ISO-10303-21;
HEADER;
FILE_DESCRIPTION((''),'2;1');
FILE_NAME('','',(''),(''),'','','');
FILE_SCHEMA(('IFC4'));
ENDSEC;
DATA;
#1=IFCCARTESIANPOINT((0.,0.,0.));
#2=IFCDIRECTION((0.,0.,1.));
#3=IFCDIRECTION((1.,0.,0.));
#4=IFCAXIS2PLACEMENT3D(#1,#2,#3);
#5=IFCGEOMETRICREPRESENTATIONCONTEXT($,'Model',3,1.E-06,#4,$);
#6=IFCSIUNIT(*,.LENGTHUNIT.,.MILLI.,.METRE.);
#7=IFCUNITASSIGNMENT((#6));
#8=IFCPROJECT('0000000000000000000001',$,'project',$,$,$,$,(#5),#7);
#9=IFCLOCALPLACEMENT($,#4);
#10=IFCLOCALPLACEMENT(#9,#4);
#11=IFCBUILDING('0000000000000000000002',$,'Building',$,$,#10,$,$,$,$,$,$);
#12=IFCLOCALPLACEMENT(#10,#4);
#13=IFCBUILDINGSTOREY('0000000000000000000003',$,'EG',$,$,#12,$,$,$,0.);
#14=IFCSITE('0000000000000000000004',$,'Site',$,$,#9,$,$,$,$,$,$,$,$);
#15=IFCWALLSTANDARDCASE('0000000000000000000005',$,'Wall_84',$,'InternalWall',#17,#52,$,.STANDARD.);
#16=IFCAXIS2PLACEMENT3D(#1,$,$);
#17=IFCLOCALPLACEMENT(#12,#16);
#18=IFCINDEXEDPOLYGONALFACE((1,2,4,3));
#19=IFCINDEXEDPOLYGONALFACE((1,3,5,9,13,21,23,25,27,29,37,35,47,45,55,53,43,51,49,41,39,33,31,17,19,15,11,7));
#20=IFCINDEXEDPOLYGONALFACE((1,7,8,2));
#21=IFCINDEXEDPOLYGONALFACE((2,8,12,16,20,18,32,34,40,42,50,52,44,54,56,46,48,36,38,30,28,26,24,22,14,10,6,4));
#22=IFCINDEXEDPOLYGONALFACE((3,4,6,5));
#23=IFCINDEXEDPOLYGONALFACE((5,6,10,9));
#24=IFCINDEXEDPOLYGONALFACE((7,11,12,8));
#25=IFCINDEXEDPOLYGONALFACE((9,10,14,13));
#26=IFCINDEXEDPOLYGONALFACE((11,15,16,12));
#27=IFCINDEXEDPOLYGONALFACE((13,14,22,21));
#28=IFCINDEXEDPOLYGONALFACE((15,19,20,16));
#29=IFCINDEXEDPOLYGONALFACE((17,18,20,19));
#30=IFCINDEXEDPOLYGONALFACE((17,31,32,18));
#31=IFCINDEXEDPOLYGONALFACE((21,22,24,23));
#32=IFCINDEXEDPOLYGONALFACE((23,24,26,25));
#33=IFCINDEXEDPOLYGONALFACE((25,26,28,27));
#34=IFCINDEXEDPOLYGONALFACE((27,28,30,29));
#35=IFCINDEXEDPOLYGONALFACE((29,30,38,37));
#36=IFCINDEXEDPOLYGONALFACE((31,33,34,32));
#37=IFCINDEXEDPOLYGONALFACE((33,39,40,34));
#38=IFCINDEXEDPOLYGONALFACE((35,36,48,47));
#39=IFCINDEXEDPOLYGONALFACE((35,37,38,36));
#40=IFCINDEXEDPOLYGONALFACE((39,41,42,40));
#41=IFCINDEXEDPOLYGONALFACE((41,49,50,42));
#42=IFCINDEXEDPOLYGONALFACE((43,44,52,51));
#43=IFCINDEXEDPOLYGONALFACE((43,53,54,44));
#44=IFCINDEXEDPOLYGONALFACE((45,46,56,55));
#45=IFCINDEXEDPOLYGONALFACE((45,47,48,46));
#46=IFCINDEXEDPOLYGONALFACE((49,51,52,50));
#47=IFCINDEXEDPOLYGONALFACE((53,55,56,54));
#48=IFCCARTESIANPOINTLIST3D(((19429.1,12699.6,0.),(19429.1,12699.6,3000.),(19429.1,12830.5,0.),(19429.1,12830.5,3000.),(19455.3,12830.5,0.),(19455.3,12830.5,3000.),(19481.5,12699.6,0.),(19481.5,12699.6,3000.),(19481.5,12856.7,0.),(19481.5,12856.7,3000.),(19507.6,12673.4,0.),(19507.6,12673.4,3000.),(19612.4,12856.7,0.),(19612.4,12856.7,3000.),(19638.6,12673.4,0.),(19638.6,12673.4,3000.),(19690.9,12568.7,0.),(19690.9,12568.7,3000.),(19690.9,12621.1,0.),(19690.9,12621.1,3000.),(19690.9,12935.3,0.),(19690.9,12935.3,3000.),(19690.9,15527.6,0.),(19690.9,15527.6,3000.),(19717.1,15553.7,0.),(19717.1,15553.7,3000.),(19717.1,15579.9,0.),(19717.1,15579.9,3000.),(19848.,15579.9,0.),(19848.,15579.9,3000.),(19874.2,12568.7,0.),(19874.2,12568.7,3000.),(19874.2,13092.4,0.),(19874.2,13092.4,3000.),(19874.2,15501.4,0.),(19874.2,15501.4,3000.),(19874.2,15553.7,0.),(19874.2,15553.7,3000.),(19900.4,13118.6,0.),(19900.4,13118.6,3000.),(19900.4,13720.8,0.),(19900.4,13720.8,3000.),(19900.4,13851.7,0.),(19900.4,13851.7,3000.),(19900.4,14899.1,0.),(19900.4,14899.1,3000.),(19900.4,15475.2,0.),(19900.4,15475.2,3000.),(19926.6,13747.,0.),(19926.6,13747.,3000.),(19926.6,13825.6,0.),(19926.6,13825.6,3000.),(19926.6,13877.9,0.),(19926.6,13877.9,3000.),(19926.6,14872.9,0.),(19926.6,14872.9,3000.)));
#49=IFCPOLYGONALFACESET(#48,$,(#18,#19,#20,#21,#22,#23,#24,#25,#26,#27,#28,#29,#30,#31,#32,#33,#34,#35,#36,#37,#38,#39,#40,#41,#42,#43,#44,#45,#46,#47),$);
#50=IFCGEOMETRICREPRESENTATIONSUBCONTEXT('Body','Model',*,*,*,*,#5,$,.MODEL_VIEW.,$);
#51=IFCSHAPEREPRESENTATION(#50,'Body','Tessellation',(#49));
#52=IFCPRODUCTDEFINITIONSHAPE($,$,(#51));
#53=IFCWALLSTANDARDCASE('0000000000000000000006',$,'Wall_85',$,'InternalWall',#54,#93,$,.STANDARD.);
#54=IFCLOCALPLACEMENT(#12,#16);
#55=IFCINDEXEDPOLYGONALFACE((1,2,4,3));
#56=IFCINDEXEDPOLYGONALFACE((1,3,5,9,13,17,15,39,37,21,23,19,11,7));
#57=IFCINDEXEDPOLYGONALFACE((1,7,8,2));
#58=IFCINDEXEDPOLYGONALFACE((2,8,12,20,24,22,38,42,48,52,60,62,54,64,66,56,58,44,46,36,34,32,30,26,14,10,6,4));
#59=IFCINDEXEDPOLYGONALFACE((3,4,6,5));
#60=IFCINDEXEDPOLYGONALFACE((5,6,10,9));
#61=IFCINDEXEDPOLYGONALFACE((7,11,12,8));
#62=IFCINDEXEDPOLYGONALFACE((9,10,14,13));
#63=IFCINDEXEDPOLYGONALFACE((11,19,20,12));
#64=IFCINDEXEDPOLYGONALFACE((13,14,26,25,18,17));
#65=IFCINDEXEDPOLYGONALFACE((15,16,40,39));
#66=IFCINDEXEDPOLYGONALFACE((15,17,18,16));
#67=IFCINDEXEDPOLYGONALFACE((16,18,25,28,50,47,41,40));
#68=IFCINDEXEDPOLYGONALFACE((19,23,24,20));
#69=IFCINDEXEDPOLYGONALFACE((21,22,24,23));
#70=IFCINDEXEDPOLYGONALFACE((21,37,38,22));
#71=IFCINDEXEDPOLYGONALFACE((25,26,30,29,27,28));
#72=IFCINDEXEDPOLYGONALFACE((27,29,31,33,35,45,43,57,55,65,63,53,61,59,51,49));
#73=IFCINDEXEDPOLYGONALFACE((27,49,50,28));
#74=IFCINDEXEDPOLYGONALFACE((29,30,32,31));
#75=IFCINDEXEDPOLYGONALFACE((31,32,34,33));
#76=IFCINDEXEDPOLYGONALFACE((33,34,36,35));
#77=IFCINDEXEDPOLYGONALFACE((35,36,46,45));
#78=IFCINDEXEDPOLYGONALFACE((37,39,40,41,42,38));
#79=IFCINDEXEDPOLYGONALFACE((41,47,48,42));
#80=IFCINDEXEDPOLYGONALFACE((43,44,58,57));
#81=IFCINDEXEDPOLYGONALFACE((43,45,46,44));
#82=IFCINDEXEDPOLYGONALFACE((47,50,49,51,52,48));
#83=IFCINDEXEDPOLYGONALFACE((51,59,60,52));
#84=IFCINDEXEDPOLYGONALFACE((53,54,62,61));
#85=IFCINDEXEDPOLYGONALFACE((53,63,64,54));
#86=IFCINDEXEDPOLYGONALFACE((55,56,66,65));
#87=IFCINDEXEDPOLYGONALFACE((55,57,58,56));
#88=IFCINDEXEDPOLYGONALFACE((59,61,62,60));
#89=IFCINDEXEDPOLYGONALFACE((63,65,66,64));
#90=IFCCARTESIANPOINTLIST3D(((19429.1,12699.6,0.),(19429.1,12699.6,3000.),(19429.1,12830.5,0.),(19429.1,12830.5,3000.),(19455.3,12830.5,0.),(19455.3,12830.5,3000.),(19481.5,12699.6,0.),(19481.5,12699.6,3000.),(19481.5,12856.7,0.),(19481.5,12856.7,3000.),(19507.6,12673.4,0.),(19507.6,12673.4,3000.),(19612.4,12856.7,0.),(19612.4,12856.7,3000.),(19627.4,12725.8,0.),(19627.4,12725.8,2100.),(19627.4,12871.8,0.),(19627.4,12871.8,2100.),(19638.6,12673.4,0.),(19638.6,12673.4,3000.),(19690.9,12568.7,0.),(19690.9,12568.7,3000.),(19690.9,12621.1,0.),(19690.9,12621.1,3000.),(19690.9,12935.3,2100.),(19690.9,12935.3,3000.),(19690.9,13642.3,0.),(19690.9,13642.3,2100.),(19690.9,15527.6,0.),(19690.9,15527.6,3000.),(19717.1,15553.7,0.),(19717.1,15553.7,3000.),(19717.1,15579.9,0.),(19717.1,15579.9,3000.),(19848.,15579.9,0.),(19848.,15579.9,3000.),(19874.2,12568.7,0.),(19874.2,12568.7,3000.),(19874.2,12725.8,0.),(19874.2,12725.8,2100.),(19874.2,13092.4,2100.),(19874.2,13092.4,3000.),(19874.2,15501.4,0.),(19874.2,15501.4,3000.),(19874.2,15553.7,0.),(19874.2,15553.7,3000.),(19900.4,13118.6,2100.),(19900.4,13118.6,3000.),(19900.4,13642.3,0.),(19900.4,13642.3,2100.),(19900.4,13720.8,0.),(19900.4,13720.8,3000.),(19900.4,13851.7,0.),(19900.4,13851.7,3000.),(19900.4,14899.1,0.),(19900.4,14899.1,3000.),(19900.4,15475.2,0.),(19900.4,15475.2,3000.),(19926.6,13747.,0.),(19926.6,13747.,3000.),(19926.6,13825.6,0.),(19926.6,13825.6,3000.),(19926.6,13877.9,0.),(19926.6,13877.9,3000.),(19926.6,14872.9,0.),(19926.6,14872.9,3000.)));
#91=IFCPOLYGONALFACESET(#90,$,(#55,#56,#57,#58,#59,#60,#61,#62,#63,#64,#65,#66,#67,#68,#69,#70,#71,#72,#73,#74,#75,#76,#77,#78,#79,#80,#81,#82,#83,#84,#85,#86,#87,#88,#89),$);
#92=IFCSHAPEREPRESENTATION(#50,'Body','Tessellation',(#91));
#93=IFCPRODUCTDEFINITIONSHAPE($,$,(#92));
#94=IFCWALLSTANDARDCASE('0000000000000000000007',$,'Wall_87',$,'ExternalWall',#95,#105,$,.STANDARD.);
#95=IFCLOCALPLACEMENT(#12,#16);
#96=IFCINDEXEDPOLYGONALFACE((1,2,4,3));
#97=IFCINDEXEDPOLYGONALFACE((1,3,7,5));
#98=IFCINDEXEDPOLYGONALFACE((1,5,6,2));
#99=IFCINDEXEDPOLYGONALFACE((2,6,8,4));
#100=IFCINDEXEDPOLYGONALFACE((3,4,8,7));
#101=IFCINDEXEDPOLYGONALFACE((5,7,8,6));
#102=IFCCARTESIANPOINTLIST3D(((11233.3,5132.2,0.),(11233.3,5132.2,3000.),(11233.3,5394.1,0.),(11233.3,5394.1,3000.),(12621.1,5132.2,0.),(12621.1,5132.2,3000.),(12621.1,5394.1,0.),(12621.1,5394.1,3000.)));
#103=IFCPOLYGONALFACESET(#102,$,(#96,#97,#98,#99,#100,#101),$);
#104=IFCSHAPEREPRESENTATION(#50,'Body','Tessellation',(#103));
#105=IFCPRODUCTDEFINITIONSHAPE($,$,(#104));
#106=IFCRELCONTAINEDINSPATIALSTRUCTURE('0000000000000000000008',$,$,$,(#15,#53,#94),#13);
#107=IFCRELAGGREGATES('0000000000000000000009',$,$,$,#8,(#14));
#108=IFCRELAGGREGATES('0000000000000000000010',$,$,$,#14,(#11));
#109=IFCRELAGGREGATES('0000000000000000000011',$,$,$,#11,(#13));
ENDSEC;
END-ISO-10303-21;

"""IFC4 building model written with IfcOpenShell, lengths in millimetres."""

from ifc_helpers import new_model, si_unit, frame, origin_with_axes, place, context, subcontext, project, spatial, polyline, rectangle, outline, extrude, element, save


model = new_model("IFC4")

# Units and contexts
model_context = context("Model", 3, precision=1e-06, world=origin_with_axes())
body_context = subcontext(model_context, "Body", "Model", "MODEL_VIEW")
ifc_project = project(units=[si_unit("LENGTHUNIT", "METRE", prefix="MILLI")], contexts=[model_context])

# Site, building, storey
site_placement = place(None, origin_with_axes())
site = spatial("IfcSite", under=ifc_project, at=site_placement, Name="Site")
building_placement = place(site_placement, origin_with_axes())
building = spatial("IfcBuilding", under=site, at=building_placement, Name="Building")
storey_placement = place(building_placement, origin_with_axes())
storey = spatial("IfcBuildingStorey", under=building, at=storey_placement, Name="EG", Elevation=0.0)

# Wall
wall_1_placement = place(storey_placement, origin_with_axes())
element("IfcWallStandardCase", 1, at=wall_1_placement, inside=storey, Name="Wall_84", ObjectType="InternalWall", PredefinedType="STANDARD", context=body_context, shape_type="SweptSolid", body=[
    extrude(outline(polyline([(19690.9, 12568.7, 0.0), (19690.9, 12621.1, 0.0), (19638.6, 12673.4, 0.0), (19507.6, 12673.4, 0.0), (19481.5, 12699.6, 0.0), (19429.1, 12699.6, 0.0), (19429.1, 12830.5, 0.0), (19455.3, 12830.5, 0.0), (19481.5, 12856.7, 0.0), (19612.4, 12856.7, 0.0), (19690.9, 12935.3, 0.0), (19690.9, 15527.6, 0.0), (19717.1, 15553.7, 0.0), (19717.1, 15579.9, 0.0), (19848.0, 15579.9, 0.0), (19874.2, 15553.7, 0.0), (19874.2, 15501.4, 0.0), (19900.4, 15475.2, 0.0), (19900.4, 14899.1, 0.0), (19926.6, 14872.9, 0.0), (19926.6, 13877.9, 0.0), (19900.4, 13851.7, 0.0), (19926.6, 13825.6, 0.0), (19926.6, 13747.0, 0.0), (19900.4, 13720.8, 0.0), (19900.4, 13118.6, 0.0), (19874.2, 13092.4, 0.0), (19874.2, 12568.7, 0.0), (19690.9, 12568.7, 0.0)])), origin_with_axes(), (0.0, 0.0, 1.0), 3000.0),
])

# Wall, opening
wall_2_placement = place(storey_placement, origin_with_axes())
wall_2 = element("IfcWallStandardCase", 2, at=wall_2_placement, inside=storey, Name="Wall_85", ObjectType="InternalWall", PredefinedType="STANDARD", context=body_context, shape_type="SweptSolid", body=[
    extrude(outline(polyline([(19690.9, 12568.7, 0.0), (19690.9, 12621.1, 0.0), (19638.6, 12673.4, 0.0), (19507.6, 12673.4, 0.0), (19481.5, 12699.6, 0.0), (19429.1, 12699.6, 0.0), (19429.1, 12830.5, 0.0), (19455.3, 12830.5, 0.0), (19481.5, 12856.7, 0.0), (19612.4, 12856.7, 0.0), (19690.9, 12935.3, 0.0), (19690.9, 15527.6, 0.0), (19717.1, 15553.7, 0.0), (19717.1, 15579.9, 0.0), (19848.0, 15579.9, 0.0), (19874.2, 15553.7, 0.0), (19874.2, 15501.4, 0.0), (19900.4, 15475.2, 0.0), (19900.4, 14899.1, 0.0), (19926.6, 14872.9, 0.0), (19926.6, 13877.9, 0.0), (19900.4, 13851.7, 0.0), (19926.6, 13825.6, 0.0), (19926.6, 13747.0, 0.0), (19900.4, 13720.8, 0.0), (19900.4, 13118.6, 0.0), (19874.2, 13092.4, 0.0), (19874.2, 12568.7, 0.0), (19690.9, 12568.7, 0.0)])), origin_with_axes(), (0.0, 0.0, 1.0), 3000.0),
])
opening_1_placement = place(wall_2_placement, origin_with_axes())
element("IfcOpeningElement", 3, at=opening_1_placement, inside=storey, cuts=wall_2, context=body_context, shape_type="SweptSolid", body=[
    extrude(rectangle(XDim=916.5, YDim=300.0), frame((19777.4, 13184.0, 0.0), z_axis=(0.0, 0.0, 1.0), x_axis=(0.0, -1.0, 0.0)), (0.0, 0.0, 1.0), 2100.0),
])

# Wall
wall_3_placement = place(storey_placement, origin_with_axes())
element("IfcWallStandardCase", 4, at=wall_3_placement, inside=storey, Name="Wall_87", ObjectType="ExternalWall", PredefinedType="STANDARD", context=body_context, shape_type="SweptSolid", body=[
    extrude(outline(polyline([(11233.3, 5132.2, 0.0), (11233.3, 5394.1, 0.0), (12621.1, 5394.1, 0.0), (12621.1, 5132.2, 0.0), (11233.3, 5132.2, 0.0)])), origin_with_axes(), (0.0, 0.0, 1.0), 3000.0),
])

save(model, "model.ifc")
